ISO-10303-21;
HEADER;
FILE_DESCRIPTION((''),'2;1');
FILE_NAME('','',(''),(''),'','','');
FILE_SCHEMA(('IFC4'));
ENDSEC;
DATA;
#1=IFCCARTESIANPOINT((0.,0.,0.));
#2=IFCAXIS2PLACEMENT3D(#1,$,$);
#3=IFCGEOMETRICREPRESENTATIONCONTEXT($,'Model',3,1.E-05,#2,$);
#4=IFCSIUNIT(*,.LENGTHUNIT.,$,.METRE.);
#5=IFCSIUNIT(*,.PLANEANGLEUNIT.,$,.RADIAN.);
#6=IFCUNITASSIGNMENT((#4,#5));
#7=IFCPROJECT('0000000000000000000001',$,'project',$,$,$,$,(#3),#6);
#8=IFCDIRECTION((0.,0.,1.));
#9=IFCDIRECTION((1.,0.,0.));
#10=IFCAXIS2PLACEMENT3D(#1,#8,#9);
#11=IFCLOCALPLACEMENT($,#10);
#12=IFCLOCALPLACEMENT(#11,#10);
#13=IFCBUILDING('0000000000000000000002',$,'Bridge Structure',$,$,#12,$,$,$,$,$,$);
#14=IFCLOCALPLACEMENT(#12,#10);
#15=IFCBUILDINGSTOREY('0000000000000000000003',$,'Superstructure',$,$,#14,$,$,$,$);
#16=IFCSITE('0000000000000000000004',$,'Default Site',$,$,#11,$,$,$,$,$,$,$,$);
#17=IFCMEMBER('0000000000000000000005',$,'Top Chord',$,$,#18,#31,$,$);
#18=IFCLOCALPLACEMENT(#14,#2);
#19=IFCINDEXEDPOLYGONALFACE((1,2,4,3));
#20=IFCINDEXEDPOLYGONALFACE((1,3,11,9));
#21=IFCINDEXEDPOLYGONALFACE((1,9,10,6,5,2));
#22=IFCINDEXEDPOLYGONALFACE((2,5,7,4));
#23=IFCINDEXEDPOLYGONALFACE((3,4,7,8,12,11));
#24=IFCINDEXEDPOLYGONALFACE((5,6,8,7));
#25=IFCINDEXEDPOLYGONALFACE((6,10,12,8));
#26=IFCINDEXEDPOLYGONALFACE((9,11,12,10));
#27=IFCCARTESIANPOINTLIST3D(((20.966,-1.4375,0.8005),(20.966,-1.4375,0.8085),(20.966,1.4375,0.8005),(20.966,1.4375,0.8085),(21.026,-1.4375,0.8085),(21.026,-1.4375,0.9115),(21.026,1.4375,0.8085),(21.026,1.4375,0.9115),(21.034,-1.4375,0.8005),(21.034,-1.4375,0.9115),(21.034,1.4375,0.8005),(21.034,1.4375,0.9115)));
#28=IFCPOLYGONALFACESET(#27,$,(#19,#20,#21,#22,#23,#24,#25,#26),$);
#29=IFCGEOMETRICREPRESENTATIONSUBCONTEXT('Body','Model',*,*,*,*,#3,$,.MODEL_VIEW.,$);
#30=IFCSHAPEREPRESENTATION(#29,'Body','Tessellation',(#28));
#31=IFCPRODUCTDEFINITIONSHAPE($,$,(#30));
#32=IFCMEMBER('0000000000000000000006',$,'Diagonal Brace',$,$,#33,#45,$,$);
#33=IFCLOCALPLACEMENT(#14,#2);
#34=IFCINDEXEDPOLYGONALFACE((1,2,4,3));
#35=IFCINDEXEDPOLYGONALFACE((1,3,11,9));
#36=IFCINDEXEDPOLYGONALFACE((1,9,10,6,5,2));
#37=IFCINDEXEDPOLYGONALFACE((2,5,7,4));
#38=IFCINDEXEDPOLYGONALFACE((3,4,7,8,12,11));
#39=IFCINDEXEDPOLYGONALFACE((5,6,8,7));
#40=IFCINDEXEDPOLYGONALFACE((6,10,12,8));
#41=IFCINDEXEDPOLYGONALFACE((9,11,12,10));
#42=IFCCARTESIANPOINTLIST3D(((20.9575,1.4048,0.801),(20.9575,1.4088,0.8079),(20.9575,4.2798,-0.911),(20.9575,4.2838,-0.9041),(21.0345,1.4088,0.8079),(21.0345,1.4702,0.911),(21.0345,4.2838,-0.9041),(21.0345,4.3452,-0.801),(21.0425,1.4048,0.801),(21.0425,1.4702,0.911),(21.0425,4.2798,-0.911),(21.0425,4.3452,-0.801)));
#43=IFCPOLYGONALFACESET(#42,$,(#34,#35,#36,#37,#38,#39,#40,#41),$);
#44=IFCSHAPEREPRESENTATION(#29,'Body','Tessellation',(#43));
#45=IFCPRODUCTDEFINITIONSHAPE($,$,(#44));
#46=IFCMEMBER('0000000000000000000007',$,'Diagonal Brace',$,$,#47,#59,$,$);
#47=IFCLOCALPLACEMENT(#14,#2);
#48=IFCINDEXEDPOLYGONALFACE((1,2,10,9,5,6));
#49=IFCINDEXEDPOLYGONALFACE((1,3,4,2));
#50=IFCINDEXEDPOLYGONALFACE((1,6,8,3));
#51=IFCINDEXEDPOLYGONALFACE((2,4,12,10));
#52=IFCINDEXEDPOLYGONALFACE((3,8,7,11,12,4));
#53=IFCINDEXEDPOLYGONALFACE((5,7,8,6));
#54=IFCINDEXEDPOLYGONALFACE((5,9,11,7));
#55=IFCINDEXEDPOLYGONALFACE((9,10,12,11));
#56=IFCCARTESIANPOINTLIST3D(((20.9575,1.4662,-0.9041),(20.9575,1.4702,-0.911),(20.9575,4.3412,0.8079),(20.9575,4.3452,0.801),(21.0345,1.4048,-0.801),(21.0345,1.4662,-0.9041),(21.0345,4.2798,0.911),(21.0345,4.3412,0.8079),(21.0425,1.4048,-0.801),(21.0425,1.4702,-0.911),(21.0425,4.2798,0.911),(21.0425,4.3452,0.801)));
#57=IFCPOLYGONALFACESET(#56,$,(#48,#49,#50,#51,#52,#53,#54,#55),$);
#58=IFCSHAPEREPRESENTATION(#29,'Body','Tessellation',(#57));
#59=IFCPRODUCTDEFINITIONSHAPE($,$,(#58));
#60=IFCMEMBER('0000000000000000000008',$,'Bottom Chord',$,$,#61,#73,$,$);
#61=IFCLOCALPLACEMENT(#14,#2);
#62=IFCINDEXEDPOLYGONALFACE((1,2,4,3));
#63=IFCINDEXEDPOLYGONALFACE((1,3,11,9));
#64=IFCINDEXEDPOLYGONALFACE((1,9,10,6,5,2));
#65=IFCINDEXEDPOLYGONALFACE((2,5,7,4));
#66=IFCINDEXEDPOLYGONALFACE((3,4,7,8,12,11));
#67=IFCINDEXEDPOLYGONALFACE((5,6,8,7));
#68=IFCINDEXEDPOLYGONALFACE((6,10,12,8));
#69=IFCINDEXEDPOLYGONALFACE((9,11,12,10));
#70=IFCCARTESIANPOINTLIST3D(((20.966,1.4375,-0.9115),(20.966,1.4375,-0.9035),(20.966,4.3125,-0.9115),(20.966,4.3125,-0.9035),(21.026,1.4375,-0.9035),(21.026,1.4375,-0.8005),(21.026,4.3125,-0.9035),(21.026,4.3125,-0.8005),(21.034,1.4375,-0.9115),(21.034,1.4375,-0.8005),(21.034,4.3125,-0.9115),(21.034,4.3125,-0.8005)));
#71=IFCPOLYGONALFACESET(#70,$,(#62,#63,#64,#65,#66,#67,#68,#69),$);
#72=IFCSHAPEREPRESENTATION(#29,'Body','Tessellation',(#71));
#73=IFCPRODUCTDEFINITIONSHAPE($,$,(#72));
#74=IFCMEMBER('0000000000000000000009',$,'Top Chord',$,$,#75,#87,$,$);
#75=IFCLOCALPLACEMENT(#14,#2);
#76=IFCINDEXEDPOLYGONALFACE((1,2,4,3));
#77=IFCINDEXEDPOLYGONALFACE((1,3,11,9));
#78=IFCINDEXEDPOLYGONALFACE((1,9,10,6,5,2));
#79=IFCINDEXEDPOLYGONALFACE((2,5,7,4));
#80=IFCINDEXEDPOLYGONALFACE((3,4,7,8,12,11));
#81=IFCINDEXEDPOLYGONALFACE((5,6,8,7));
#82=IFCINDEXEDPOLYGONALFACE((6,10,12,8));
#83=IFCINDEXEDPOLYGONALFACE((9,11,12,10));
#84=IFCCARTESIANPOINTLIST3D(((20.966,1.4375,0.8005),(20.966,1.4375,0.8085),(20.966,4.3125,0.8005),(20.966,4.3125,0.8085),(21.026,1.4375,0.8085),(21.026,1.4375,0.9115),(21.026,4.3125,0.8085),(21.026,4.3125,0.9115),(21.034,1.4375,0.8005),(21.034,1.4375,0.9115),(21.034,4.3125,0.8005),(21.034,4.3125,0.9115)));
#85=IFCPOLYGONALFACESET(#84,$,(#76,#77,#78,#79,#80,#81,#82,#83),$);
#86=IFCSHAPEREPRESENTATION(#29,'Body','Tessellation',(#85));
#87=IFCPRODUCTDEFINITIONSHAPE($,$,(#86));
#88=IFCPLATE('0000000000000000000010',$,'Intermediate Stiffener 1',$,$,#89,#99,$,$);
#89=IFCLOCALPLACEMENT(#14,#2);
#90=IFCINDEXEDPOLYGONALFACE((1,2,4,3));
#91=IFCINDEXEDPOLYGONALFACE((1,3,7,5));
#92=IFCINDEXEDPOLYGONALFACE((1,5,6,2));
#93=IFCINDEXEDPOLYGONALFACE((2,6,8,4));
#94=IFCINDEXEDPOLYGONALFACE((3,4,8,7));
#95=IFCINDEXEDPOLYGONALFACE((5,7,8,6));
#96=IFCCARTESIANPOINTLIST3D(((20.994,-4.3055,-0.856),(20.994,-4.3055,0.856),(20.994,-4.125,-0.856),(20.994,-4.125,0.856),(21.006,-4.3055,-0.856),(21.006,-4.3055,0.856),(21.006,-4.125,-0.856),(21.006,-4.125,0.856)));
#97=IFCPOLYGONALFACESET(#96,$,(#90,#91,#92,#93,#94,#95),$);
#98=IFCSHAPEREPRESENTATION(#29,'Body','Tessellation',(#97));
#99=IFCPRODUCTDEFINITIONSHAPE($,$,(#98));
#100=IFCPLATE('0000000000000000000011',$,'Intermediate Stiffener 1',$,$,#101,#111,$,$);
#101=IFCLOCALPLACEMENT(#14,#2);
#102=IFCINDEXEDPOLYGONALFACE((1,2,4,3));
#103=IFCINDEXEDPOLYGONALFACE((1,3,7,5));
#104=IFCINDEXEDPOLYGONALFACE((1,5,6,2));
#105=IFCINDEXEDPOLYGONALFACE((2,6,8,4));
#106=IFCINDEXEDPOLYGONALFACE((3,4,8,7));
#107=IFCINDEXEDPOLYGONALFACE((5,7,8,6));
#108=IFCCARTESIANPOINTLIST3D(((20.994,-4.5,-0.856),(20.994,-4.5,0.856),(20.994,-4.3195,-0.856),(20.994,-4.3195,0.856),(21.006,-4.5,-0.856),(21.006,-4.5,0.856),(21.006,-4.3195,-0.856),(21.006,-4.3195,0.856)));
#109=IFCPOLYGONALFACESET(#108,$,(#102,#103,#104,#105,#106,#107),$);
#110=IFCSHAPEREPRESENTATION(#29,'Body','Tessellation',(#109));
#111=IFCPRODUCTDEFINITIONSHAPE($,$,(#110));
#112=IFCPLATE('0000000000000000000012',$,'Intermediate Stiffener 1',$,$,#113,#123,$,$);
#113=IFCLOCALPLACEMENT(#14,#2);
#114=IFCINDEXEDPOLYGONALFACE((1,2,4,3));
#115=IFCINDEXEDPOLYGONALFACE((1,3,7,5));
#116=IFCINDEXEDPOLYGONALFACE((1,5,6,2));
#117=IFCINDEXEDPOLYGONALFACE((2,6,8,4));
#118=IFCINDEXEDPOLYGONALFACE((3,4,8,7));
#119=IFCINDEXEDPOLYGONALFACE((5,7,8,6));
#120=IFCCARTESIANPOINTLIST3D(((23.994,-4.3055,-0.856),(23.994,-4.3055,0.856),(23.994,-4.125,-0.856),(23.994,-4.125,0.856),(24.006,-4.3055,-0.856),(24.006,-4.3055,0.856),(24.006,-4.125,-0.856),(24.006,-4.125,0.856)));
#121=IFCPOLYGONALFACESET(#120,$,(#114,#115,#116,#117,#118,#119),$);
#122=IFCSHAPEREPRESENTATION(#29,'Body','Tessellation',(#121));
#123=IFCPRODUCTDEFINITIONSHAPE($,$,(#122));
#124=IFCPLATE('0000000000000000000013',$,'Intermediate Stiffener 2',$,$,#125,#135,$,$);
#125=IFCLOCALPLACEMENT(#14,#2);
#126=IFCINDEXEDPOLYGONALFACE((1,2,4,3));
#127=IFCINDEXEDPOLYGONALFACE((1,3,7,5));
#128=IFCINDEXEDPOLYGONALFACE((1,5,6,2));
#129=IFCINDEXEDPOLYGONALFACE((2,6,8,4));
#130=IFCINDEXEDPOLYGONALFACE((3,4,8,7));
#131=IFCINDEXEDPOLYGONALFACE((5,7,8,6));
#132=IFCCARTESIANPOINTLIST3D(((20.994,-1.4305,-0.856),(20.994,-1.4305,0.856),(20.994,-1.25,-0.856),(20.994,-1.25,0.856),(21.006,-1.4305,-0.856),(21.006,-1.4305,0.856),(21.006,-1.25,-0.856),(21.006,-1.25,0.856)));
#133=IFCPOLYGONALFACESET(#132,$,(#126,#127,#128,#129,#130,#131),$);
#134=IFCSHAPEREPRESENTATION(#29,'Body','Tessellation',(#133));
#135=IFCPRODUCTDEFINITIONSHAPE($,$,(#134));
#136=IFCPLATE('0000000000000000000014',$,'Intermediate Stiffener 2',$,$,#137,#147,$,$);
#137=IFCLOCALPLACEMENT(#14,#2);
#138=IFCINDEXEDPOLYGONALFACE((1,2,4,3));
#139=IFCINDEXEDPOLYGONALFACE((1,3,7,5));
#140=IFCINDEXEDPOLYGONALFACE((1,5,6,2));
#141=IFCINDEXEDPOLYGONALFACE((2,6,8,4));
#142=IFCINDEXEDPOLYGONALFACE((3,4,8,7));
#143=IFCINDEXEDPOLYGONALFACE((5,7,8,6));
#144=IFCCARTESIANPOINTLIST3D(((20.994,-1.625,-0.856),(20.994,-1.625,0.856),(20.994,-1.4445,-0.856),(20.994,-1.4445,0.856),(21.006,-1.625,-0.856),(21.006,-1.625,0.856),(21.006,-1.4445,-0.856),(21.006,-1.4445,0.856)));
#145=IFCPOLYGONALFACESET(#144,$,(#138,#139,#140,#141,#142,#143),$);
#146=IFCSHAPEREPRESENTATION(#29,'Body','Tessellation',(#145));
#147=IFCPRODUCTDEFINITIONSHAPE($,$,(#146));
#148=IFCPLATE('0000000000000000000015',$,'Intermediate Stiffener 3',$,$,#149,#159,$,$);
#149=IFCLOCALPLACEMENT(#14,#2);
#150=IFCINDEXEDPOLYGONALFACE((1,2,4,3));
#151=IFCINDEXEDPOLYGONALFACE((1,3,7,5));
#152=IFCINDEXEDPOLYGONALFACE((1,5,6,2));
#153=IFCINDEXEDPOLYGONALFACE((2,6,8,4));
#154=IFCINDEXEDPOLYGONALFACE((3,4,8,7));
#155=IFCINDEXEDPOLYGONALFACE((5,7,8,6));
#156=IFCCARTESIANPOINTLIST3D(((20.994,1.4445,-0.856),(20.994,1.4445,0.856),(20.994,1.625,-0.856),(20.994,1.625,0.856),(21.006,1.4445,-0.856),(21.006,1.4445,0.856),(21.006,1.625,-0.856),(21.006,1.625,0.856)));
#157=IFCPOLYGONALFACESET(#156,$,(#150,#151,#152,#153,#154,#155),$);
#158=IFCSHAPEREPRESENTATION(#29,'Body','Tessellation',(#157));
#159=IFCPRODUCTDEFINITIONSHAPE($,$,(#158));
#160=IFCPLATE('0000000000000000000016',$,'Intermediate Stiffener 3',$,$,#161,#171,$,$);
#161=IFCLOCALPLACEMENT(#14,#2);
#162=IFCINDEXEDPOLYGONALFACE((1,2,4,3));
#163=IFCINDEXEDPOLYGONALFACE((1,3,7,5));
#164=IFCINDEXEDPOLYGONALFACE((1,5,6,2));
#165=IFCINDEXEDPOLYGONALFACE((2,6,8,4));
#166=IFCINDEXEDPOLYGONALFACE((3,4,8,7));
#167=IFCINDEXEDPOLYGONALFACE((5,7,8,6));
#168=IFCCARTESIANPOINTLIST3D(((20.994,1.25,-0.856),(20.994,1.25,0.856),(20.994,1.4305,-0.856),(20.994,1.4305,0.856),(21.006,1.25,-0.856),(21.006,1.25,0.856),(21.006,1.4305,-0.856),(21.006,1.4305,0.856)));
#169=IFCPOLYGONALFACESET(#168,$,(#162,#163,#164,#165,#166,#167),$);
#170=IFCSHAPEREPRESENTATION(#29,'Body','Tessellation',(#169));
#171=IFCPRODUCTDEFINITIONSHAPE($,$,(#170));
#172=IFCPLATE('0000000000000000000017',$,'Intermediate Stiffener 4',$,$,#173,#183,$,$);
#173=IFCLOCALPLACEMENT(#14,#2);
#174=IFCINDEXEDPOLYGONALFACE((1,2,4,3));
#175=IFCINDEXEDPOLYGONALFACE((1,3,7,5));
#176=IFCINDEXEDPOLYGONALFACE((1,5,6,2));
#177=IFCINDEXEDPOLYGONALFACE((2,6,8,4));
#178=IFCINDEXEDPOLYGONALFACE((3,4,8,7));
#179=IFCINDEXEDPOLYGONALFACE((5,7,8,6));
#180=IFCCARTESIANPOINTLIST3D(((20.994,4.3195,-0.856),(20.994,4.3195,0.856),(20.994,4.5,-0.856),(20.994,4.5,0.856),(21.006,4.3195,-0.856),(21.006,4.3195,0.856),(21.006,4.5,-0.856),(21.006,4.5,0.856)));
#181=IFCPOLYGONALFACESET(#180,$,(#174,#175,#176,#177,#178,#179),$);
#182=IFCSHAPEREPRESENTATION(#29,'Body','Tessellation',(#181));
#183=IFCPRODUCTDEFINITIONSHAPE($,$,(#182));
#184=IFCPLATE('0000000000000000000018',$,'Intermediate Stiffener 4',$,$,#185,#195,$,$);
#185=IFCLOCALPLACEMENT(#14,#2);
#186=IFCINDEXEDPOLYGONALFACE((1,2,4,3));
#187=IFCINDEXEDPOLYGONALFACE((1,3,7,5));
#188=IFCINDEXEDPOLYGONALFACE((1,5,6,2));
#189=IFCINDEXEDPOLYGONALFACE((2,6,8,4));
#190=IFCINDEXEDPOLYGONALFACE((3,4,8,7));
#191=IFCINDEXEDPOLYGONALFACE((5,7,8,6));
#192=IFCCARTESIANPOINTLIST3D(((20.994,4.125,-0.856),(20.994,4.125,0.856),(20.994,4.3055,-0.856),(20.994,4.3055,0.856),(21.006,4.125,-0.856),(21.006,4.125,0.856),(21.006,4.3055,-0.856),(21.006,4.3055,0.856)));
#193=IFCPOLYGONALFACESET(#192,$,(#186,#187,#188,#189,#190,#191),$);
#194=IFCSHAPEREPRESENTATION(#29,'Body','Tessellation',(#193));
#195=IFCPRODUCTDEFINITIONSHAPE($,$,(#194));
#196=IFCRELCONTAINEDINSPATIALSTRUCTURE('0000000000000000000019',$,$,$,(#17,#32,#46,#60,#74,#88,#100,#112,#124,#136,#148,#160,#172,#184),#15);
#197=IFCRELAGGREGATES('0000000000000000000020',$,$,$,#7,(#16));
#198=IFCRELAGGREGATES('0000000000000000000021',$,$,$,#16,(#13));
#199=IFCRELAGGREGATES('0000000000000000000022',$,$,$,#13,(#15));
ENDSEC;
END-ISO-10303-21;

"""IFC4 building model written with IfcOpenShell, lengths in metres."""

from ifc_helpers import new_model, si_unit, frame, origin, origin_with_axes, origin_2d_with_axis, place, context, subcontext, project, spatial, rectangle, l_section, extrude, element, save


model = new_model("IFC4")

# Units and contexts
model_context = context("Model", 3, precision=1e-05, world=origin())
body_context = subcontext(model_context, "Body", "Model", "MODEL_VIEW")
ifc_project = project(units=[si_unit("LENGTHUNIT", "METRE"), si_unit("PLANEANGLEUNIT", "RADIAN")], contexts=[model_context])

# Site, building, storey
site_placement = place(None, origin_with_axes())
site = spatial("IfcSite", under=ifc_project, at=site_placement, Name="Default Site")
building_placement = place(site_placement, origin_with_axes())
building = spatial("IfcBuilding", under=site, at=building_placement, Name="Bridge Structure")
storey_placement = place(building_placement, origin_with_axes())
storey = spatial("IfcBuildingStorey", under=building, at=storey_placement, Name="Superstructure")

# Members
for number, where, z_axis, x_axis, name in (
    (1, (21.0, -1.4375, 0.856), (0.0, 1.0, 0.0), (-1.0, 0.0, 0.0), "Top Chord"),
):
    element("IfcMember", number, at=place(storey_placement, frame(where, z_axis=z_axis, x_axis=x_axis)), inside=storey, Name=name, context=body_context, shape_type="SweptSolid", body=[
        extrude(l_section(Depth=0.111, Width=0.068, Thickness=0.008, at=origin_2d_with_axis()), origin_with_axes(), (0.0, 0.0, 1.0), 2.875),
    ])
for number, where, z_axis, x_axis, name in (
    (2, (21.0, 1.4375, 0.856), (0.0, 0.859202, -0.511636), (-1.0, 0.0, 0.0), "Diagonal Brace"),
    (3, (21.0, 1.4375, -0.856), (0.0, 0.859202, 0.511636), (-1.0, 0.0, 0.0), "Diagonal Brace"),
):
    element("IfcMember", number, at=place(storey_placement, frame(where, z_axis=z_axis, x_axis=x_axis)), inside=storey, Name=name, context=body_context, shape_type="SweptSolid", body=[
        extrude(l_section(Depth=0.128, Width=0.085, Thickness=0.008, at=origin_2d_with_axis()), origin_with_axes(), (0.0, 0.0, 1.0), 3.3461),
    ])
for number, where, z_axis, x_axis, name in (
    (4, (21.0, 1.4375, -0.856), (0.0, 1.0, 0.0), (-1.0, 0.0, 0.0), "Bottom Chord"),
    (5, (21.0, 1.4375, 0.856), (0.0, 1.0, 0.0), (-1.0, 0.0, 0.0), "Top Chord"),
):
    element("IfcMember", number, at=place(storey_placement, frame(where, z_axis=z_axis, x_axis=x_axis)), inside=storey, Name=name, context=body_context, shape_type="SweptSolid", body=[
        extrude(l_section(Depth=0.111, Width=0.068, Thickness=0.008, at=origin_2d_with_axis()), origin_with_axes(), (0.0, 0.0, 1.0), 2.875),
    ])

# Plates
for number, where, z_axis, x_axis, name in (
    (6, (21.0, -4.2153, -0.856), (0.0, 0.0, 1.0), (1.0, 0.0, 0.0), "Intermediate Stiffener 1"),
    (7, (21.0, -4.4097, -0.856), (0.0, 0.0, 1.0), (1.0, 0.0, 0.0), "Intermediate Stiffener 1"),
    (8, (24.0, -4.2153, -0.856), (0.0, 0.0, 1.0), (1.0, 0.0, 0.0), "Intermediate Stiffener 1"),
    (9, (21.0, -1.3402, -0.856), (0.0, 0.0, 1.0), (1.0, 0.0, 0.0), "Intermediate Stiffener 2"),
    (10, (21.0, -1.5348, -0.856), (0.0, 0.0, 1.0), (1.0, 0.0, 0.0), "Intermediate Stiffener 2"),
    (11, (21.0, 1.5348, -0.856), (0.0, 0.0, 1.0), (1.0, 0.0, 0.0), "Intermediate Stiffener 3"),
    (12, (21.0, 1.3402, -0.856), (0.0, 0.0, 1.0), (1.0, 0.0, 0.0), "Intermediate Stiffener 3"),
    (13, (21.0, 4.4097, -0.856), (0.0, 0.0, 1.0), (1.0, 0.0, 0.0), "Intermediate Stiffener 4"),
    (14, (21.0, 4.2153, -0.856), (0.0, 0.0, 1.0), (1.0, 0.0, 0.0), "Intermediate Stiffener 4"),
):
    element("IfcPlate", number, at=place(storey_placement, frame(where, z_axis=z_axis, x_axis=x_axis)), inside=storey, Name=name, context=body_context, shape_type="SweptSolid", body=[
        extrude(rectangle(XDim=0.012, YDim=0.1805, at=origin_2d_with_axis()), origin_with_axes(), (0.0, 0.0, 1.0), 1.712),
    ])

save(model, "model.ifc")
